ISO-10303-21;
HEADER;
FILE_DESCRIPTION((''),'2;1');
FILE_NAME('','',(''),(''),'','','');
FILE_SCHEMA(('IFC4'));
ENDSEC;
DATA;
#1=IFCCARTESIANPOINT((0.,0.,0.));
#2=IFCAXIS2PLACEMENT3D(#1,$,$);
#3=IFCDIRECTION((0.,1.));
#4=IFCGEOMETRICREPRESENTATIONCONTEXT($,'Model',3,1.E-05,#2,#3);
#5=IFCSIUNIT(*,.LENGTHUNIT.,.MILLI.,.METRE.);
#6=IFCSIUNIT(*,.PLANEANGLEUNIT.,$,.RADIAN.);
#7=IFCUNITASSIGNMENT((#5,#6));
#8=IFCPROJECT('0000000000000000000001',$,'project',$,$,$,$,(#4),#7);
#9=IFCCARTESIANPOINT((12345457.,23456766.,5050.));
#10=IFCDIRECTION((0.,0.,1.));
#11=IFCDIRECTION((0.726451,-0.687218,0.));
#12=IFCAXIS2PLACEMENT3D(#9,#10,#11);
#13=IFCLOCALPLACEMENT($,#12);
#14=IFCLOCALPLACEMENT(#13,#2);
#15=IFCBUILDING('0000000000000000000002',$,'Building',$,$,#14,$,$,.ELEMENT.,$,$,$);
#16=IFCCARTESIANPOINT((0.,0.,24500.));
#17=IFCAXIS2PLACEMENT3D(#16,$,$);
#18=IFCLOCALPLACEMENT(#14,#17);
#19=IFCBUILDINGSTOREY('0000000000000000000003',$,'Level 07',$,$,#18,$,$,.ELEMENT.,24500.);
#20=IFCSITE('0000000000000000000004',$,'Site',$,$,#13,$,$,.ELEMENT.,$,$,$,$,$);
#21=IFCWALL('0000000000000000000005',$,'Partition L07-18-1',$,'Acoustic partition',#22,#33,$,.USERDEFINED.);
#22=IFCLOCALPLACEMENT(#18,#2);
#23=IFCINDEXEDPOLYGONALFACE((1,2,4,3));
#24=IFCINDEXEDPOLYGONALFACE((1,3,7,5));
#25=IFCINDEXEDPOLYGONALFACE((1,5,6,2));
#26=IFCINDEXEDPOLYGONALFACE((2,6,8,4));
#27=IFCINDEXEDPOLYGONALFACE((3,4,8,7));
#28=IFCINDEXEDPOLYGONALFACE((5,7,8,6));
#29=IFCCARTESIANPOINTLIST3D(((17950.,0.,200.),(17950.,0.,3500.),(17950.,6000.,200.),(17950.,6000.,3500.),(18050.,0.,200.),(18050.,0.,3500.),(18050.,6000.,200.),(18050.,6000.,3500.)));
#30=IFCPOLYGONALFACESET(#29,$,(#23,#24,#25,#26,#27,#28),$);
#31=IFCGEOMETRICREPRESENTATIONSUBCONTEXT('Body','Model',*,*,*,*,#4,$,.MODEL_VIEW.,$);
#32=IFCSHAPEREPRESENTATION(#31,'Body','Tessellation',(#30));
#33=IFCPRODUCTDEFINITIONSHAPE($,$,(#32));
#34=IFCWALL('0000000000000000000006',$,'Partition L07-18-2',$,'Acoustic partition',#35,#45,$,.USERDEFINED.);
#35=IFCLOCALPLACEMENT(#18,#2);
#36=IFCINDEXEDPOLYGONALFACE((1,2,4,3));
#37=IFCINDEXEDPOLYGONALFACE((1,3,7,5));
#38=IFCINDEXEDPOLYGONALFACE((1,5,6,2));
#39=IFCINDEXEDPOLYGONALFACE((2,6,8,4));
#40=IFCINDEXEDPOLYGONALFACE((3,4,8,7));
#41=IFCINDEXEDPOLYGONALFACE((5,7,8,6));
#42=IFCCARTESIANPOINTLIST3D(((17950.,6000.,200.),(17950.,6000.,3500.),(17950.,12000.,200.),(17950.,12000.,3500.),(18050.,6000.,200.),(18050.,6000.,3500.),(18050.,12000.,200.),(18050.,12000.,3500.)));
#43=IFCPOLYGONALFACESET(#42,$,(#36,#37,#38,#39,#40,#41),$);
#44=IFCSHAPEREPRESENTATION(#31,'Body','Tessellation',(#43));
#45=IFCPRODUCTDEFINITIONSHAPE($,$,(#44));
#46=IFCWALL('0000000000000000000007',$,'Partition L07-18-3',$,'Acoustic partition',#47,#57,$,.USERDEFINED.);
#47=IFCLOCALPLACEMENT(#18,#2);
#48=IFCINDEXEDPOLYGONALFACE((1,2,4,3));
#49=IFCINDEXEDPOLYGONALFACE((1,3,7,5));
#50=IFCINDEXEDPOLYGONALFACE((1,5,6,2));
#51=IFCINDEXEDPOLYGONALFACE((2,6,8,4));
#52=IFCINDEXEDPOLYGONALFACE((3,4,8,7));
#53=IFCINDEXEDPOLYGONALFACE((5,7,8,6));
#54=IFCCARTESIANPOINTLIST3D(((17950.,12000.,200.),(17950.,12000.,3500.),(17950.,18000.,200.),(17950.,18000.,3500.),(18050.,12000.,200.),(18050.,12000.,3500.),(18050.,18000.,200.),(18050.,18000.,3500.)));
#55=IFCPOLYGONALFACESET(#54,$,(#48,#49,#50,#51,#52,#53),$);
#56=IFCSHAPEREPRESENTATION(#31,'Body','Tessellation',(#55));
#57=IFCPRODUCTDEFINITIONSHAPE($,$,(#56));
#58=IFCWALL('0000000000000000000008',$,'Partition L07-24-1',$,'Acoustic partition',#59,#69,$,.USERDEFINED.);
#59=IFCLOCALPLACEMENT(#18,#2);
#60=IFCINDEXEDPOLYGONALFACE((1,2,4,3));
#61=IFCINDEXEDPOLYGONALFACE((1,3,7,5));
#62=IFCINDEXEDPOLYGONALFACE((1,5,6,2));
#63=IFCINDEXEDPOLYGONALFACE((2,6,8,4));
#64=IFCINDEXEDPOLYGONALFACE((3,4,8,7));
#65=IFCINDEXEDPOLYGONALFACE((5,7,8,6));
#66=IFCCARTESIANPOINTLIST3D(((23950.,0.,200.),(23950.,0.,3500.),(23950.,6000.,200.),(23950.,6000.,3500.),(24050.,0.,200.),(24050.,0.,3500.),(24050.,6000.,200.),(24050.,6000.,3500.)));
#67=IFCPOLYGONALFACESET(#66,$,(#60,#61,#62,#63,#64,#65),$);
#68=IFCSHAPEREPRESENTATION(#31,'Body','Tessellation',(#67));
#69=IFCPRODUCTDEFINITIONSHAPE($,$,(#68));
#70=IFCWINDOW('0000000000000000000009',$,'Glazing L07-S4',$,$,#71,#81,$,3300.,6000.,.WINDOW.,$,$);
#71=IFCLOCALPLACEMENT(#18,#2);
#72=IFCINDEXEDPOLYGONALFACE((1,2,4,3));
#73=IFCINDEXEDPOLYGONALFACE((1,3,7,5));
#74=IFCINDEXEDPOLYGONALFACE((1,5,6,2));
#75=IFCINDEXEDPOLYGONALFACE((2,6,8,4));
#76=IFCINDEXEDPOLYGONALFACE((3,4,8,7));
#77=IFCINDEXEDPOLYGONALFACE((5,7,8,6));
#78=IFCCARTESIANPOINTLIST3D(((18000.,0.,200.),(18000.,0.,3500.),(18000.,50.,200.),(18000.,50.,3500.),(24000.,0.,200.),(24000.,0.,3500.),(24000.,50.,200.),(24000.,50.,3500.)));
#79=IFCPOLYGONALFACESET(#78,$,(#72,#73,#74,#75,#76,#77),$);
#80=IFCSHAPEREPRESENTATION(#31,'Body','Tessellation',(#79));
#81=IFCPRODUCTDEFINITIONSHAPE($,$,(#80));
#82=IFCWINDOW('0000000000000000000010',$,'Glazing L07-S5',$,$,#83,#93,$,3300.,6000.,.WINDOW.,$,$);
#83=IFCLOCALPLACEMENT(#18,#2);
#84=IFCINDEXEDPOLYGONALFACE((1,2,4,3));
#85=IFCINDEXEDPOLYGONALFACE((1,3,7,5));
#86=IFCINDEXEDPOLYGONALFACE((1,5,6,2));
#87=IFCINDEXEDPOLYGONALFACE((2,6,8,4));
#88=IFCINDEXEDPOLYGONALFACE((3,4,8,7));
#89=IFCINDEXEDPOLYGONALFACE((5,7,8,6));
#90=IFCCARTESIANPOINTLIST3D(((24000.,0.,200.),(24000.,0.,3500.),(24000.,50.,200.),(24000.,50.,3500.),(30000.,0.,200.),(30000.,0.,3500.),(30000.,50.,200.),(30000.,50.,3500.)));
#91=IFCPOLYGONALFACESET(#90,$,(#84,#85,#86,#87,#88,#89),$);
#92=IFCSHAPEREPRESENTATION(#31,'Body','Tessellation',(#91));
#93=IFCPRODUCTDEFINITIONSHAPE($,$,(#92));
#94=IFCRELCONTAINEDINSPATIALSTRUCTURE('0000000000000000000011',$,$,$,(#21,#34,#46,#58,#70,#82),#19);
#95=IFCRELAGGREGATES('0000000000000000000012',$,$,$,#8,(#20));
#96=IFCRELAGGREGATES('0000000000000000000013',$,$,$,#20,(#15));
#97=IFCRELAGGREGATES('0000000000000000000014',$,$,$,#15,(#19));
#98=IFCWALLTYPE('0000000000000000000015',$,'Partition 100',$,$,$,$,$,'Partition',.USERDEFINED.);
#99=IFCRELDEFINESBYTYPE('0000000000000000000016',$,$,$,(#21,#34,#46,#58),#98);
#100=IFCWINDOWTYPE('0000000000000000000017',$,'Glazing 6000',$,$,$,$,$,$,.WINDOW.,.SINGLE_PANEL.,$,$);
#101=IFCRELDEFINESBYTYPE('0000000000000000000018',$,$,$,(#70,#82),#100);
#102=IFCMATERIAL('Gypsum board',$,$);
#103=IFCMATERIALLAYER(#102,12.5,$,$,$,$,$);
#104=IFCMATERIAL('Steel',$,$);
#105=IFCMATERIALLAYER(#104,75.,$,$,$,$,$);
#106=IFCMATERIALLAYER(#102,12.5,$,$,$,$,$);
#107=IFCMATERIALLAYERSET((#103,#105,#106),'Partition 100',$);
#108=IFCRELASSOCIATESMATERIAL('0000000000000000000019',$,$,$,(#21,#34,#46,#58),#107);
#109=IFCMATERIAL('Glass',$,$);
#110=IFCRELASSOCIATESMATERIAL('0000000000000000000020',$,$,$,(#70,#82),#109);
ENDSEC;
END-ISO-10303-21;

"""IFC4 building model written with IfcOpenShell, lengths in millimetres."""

from ifc_helpers import new_model, si_unit, direction, frame, origin, place, context, subcontext, project, spatial, rectangle, extrude, material, layer, layer_set, layer_usage, type_object, element, save


model = new_model("IFC4")

# Units and contexts
model_context = context("Model", 3, precision=1e-05, world=origin(), true_north=direction((0.0, 1.0)))
body_context = subcontext(model_context, "Body", "Model", "MODEL_VIEW")
ifc_project = project(units=[si_unit("LENGTHUNIT", "METRE", prefix="MILLI"), si_unit("PLANEANGLEUNIT", "RADIAN")], contexts=[model_context])

# Site, building, storey
site_placement = place(None, frame((12345457.0, 23456766.0, 5050.0), z_axis=(0.0, 0.0, 1.0), x_axis=(0.726451, -0.687218, 0.0)))
site = spatial("IfcSite", under=ifc_project, at=site_placement, Name="Site", CompositionType="ELEMENT")
building_placement = place(site_placement, origin())
building = spatial("IfcBuilding", under=site, at=building_placement, Name="Building", CompositionType="ELEMENT")
storey_placement = place(building_placement, frame((0.0, 0.0, 24500.0)))
storey = spatial("IfcBuildingStorey", under=building, at=storey_placement, Name="Level 07", CompositionType="ELEMENT", Elevation=24500.0)

# Shared definitions
ifc_material_1 = material(Name="Steel")

# Walls
ifc_material_2 = material(Name="Gypsum board")
ifc_layer_1 = layer(ifc_material_2, 12.5)
ifc_layer_2 = layer(ifc_material_1, 75.0)
ifc_layer_3 = layer(ifc_material_2, 12.5)
ifc_layer_set = layer_set([ifc_layer_1, ifc_layer_2, ifc_layer_3], Name="Partition 100")
ifc_layer_usage = layer_usage(ifc_layer_set, "AXIS2", "POSITIVE", 0.0)
wall_type = type_object("IfcWallType", Name="Partition 100", ElementType="Partition", PredefinedType="USERDEFINED")
for number, where, name in (
    (1, (17950.0, 0.0, 200.0), "Partition L07-18-1"),
    (2, (17950.0, 6000.0, 200.0), "Partition L07-18-2"),
    (3, (17950.0, 12000.0, 200.0), "Partition L07-18-3"),
    (4, (23950.0, 0.0, 200.0), "Partition L07-24-1"),
):
    element("IfcWall", number, at=place(storey_placement, frame(where)), inside=storey, type_object=wall_type, material=ifc_layer_usage, Name=name, ObjectType="Acoustic partition", PredefinedType="USERDEFINED", context=body_context, shape_type="SweptSolid", body=[
        extrude(rectangle(XDim=100.0, YDim=6000.0), frame((50.0, 3000.0, 0.0)), (0.0, 0.0, 1.0), 3300.0),
    ])

# Windows
ifc_material_3 = material(Name="Glass")
window_type = type_object("IfcWindowType", Name="Glazing 6000", PartitioningType="SINGLE_PANEL", PredefinedType="WINDOW")
for number, where, name in (
    (5, (18000.0, 0.0, 200.0), "Glazing L07-S4"),
    (6, (24000.0, 0.0, 200.0), "Glazing L07-S5"),
):
    element("IfcWindow", number, at=place(storey_placement, frame(where)), inside=storey, type_object=window_type, material=ifc_material_3, Name=name, OverallHeight=3300.0, OverallWidth=6000.0, PredefinedType="WINDOW", context=body_context, shape_type="SweptSolid", body=[
        extrude(rectangle(XDim=6000.0, YDim=50.0), frame((3000.0, 25.0, 0.0)), (0.0, 0.0, 1.0), 3300.0),
    ])

save(model, "model.ifc")
